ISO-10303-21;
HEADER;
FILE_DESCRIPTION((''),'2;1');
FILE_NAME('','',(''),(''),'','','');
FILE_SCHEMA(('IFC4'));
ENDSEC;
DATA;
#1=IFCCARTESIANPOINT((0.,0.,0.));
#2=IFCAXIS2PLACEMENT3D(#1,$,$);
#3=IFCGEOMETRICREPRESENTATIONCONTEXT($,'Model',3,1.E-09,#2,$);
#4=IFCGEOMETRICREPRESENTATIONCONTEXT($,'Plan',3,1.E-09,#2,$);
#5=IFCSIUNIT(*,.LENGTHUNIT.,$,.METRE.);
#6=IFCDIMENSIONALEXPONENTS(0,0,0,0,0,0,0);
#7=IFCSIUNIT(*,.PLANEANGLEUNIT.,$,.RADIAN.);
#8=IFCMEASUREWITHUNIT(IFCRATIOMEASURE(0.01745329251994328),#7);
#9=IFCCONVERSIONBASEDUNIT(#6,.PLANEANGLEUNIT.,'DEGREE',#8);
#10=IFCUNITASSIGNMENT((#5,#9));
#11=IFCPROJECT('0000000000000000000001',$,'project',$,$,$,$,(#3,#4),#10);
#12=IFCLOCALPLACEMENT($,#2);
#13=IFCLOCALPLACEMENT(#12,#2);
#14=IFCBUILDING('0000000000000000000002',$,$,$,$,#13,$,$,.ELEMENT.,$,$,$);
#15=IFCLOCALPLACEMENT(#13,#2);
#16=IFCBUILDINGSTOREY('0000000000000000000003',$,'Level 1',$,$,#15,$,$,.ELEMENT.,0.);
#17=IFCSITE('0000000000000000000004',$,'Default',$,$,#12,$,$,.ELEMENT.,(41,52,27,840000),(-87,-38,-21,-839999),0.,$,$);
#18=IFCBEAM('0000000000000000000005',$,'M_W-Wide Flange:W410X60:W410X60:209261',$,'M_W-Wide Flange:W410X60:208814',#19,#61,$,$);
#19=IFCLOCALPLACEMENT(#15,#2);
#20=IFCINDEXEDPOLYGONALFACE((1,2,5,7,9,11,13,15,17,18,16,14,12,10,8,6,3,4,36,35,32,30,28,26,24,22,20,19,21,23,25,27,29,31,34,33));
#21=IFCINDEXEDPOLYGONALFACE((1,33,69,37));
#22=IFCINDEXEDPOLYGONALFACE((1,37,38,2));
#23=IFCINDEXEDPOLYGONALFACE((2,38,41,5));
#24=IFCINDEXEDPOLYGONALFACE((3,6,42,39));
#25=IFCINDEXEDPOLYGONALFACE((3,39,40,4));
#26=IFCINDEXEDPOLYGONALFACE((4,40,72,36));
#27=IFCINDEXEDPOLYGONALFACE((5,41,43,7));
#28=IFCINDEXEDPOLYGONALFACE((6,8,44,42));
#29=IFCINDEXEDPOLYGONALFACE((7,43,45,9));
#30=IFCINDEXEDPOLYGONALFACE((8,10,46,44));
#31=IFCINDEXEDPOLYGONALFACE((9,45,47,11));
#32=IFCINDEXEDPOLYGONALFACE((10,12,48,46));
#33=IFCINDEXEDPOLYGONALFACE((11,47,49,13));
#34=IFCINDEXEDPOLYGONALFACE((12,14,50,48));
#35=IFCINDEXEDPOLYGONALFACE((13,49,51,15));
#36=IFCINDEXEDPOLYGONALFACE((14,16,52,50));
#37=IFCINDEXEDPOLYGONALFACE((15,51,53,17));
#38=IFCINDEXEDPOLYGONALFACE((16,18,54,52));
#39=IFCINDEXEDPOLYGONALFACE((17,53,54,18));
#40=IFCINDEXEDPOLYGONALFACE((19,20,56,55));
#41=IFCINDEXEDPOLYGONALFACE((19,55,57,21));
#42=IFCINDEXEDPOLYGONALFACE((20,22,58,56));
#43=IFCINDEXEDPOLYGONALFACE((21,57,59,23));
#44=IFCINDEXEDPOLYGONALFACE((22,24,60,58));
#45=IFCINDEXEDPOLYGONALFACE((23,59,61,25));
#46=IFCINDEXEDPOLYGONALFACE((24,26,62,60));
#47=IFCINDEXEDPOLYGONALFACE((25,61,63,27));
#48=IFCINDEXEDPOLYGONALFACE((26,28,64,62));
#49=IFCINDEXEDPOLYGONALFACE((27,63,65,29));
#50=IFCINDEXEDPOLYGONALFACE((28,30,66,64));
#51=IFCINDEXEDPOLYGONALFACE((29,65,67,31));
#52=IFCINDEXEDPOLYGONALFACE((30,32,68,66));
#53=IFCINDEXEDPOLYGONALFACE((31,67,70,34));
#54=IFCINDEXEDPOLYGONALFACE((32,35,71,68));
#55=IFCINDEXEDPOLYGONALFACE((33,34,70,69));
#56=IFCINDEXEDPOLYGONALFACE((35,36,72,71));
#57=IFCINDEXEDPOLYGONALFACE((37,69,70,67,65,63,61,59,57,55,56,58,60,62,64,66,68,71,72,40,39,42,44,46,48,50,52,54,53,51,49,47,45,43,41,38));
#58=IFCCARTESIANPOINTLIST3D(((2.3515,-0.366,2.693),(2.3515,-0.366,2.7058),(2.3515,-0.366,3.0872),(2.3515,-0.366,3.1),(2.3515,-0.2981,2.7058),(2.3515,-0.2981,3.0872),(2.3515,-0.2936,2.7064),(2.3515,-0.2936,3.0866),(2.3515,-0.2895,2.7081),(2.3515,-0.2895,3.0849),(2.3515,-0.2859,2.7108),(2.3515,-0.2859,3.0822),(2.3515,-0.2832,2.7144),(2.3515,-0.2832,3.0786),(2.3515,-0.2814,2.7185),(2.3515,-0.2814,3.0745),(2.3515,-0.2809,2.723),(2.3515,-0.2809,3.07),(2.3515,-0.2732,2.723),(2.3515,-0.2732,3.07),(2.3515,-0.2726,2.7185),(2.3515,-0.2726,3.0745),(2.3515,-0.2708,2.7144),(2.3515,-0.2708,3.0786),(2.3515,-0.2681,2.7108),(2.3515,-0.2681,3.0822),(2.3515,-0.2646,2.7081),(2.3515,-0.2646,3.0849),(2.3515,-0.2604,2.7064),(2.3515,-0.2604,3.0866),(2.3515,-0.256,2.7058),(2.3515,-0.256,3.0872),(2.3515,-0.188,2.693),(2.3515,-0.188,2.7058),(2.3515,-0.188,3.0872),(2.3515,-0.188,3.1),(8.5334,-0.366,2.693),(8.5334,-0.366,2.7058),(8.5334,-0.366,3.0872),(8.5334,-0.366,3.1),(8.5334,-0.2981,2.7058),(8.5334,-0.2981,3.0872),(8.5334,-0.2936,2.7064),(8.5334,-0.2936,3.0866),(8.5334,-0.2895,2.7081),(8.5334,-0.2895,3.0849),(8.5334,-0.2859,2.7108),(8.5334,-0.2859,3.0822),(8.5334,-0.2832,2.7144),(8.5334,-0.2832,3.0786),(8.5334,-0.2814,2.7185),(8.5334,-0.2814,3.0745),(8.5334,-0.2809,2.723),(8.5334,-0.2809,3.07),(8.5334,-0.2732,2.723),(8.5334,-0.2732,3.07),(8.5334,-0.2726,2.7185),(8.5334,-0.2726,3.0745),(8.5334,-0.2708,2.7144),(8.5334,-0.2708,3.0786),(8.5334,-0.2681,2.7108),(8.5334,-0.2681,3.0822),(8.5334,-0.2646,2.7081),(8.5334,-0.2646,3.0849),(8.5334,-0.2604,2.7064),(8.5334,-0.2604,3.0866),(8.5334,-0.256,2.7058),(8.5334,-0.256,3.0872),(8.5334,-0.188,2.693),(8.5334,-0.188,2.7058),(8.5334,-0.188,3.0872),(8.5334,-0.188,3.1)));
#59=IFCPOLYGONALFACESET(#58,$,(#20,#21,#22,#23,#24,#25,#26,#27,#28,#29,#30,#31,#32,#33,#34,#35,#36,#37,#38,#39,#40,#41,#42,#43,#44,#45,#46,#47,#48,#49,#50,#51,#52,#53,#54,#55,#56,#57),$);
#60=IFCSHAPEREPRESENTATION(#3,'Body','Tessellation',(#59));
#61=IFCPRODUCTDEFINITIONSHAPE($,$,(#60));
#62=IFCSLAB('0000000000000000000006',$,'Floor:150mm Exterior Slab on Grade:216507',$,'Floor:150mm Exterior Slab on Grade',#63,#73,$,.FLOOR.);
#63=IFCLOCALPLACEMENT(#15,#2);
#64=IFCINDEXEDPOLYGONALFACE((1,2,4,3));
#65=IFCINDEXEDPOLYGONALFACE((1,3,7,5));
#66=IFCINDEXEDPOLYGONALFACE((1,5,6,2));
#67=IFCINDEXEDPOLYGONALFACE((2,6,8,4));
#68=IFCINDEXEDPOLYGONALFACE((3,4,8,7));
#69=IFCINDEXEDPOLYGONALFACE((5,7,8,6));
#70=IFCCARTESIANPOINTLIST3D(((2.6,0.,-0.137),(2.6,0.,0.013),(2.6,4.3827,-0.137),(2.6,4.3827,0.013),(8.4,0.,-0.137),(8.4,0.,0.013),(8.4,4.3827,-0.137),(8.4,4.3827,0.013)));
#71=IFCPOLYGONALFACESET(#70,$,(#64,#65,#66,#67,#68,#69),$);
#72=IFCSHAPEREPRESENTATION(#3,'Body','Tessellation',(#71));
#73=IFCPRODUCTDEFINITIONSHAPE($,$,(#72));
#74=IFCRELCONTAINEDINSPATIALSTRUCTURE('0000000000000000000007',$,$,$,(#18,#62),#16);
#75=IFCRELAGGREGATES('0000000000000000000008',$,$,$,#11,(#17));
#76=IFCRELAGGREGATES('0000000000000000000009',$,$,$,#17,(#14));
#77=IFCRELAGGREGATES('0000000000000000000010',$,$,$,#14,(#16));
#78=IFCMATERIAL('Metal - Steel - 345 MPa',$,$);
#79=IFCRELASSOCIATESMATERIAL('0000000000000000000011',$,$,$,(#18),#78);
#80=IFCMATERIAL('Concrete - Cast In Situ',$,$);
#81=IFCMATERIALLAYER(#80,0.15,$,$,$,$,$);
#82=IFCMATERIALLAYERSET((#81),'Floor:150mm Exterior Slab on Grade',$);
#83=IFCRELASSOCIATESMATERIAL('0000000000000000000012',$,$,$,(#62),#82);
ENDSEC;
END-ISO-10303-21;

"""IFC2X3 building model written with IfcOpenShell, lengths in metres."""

from ifc_helpers import new_model, entity, si_unit, converted_unit, frame, frame_2d, origin, place, context, project, spatial, polyline, circle_curve, parameter, trimmed, segment, composite_curve, rectangle, outline, extrude, material, layer, layer_set, layer_usage, element, save


model = new_model("IFC2X3")

# Units and contexts
model_context = context("Model", 3, precision=1e-09, world=origin())
plan_context = context("Plan", 3, precision=1e-09, world=origin())
ifc_project = project(units=[si_unit("LENGTHUNIT", "METRE"), converted_unit("PLANEANGLEUNIT", "DEGREE", entity("IfcRatioMeasure", 0.01745329251994328), si_unit("PLANEANGLEUNIT", "RADIAN"), dimensions=[0, 0, 0, 0, 0, 0, 0])], contexts=[model_context, plan_context])

# Site, building, storey
site_placement = place(None, origin())
site = spatial("IfcSite", under=ifc_project, at=site_placement, Name="Default", CompositionType="ELEMENT", RefLatitude=(41, 52, 27, 840000), RefLongitude=(-87, -38, -21, -839999), RefElevation=0.0)
building_placement = place(site_placement, origin())
building = spatial("IfcBuilding", under=site, at=building_placement, CompositionType="ELEMENT")
storey_placement = place(building_placement, origin())
storey = spatial("IfcBuildingStorey", under=building, at=storey_placement, Name="Level 1", CompositionType="ELEMENT", Elevation=0.0)

# Beam
ifc_material_1 = material(Name="Metal - Steel - 345 MPa")
beam_placement = place(storey_placement, frame((8.5915, -0.277, 3.1), z_axis=(0.0, 0.0, 1.0), x_axis=(0.0, 1.0, 0.0)))
element("IfcBeam", 1, at=beam_placement, inside=storey, material=ifc_material_1, Name="M_W-Wide Flange:W410X60:W410X60:209261", ObjectType="M_W-Wide Flange:W410X60:208814", context=model_context, shape_type="SweptSolid", body=[
    extrude(outline(composite_curve([segment(polyline([(0.1907, -0.089), (0.2035, -0.089)]), True, "CONTINUOUS"), segment(polyline([(0.2035, -0.089), (0.2035, 0.089)]), True, "CONTINUOUS"), segment(polyline([(0.2035, 0.089), (0.1907, 0.089)]), True, "CONTINUOUS"), segment(polyline([(0.1907, 0.089), (0.1907, 0.021)]), True, "CONTINUOUS"), segment(trimmed(circle_curve(frame_2d((0.1735, 0.021), x_axis=(1.0, 0.0)), 0.0172), [parameter(270.0)], [parameter(360.0)], True, "PARAMETER"), False, "CONTINUOUS"), segment(polyline([(0.1735, 0.0038), (-0.1735, 0.0038)]), True, "CONTINUOUS"), segment(trimmed(circle_curve(frame_2d((-0.1735, 0.021), x_axis=(0.0, -1.0)), 0.0172), [parameter(270.0)], [parameter(360.0)], True, "PARAMETER"), False, "CONTINUOUS"), segment(polyline([(-0.1907, 0.021), (-0.1907, 0.089)]), True, "CONTINUOUS"), segment(polyline([(-0.1907, 0.089), (-0.2035, 0.089)]), True, "CONTINUOUS"), segment(polyline([(-0.2035, 0.089), (-0.2035, -0.089)]), True, "CONTINUOUS"), segment(polyline([(-0.2035, -0.089), (-0.1907, -0.089)]), True, "CONTINUOUS"), segment(polyline([(-0.1907, -0.089), (-0.1907, -0.0211)]), True, "CONTINUOUS"), segment(trimmed(circle_curve(frame_2d((-0.1735, -0.0211), x_axis=(-1.0, 0.0)), 0.0172), [parameter(270.0)], [parameter(0.0)], True, "PARAMETER"), False, "CONTINUOUS"), segment(polyline([(-0.1735, -0.0039), (0.1735, -0.0039)]), True, "CONTINUOUS"), segment(trimmed(circle_curve(frame_2d((0.1735, -0.0211), x_axis=(0.0, 1.0)), 0.0172), [parameter(270.0)], [parameter(0.0)], True, "PARAMETER"), False, "CONTINUOUS"), segment(polyline([(0.1907, -0.0211), (0.1907, -0.089)]), True, "CONTINUOUS")], self_intersect=False)), frame((0.0, 6.24, -0.2035), z_axis=(0.0, -1.0, 0.0), x_axis=(0.0, 0.0, -1.0)), (0.0, 0.0, 1.0), 6.1819),
])

# Slab
ifc_material_2 = material(Name="Concrete - Cast In Situ")
ifc_layer_1 = layer(ifc_material_2, 0.15)
ifc_layer_set_1 = layer_set([ifc_layer_1], Name="Floor:150mm Exterior Slab on Grade")
ifc_layer_usage_1 = layer_usage(ifc_layer_set_1, "AXIS3", "POSITIVE", 0.0)
slab_placement = place(storey_placement, frame((2.6, 0.0, -0.137)))
element("IfcSlab", 2, at=slab_placement, inside=storey, material=ifc_layer_usage_1, Name="Floor:150mm Exterior Slab on Grade:216507", ObjectType="Floor:150mm Exterior Slab on Grade", PredefinedType="FLOOR", context=model_context, shape_type="SweptSolid", body=[
    extrude(rectangle(XDim=5.8, YDim=4.3827, at=frame_2d((0.0, 0.0), x_axis=(-1.0, 0.0))), frame((2.9, 2.1914, 0.15), z_axis=(0.0, 0.0, -1.0), x_axis=(-1.0, 0.0, 0.0)), (0.0, 0.0, 1.0), 0.15),
])

save(model, "model.ifc")
